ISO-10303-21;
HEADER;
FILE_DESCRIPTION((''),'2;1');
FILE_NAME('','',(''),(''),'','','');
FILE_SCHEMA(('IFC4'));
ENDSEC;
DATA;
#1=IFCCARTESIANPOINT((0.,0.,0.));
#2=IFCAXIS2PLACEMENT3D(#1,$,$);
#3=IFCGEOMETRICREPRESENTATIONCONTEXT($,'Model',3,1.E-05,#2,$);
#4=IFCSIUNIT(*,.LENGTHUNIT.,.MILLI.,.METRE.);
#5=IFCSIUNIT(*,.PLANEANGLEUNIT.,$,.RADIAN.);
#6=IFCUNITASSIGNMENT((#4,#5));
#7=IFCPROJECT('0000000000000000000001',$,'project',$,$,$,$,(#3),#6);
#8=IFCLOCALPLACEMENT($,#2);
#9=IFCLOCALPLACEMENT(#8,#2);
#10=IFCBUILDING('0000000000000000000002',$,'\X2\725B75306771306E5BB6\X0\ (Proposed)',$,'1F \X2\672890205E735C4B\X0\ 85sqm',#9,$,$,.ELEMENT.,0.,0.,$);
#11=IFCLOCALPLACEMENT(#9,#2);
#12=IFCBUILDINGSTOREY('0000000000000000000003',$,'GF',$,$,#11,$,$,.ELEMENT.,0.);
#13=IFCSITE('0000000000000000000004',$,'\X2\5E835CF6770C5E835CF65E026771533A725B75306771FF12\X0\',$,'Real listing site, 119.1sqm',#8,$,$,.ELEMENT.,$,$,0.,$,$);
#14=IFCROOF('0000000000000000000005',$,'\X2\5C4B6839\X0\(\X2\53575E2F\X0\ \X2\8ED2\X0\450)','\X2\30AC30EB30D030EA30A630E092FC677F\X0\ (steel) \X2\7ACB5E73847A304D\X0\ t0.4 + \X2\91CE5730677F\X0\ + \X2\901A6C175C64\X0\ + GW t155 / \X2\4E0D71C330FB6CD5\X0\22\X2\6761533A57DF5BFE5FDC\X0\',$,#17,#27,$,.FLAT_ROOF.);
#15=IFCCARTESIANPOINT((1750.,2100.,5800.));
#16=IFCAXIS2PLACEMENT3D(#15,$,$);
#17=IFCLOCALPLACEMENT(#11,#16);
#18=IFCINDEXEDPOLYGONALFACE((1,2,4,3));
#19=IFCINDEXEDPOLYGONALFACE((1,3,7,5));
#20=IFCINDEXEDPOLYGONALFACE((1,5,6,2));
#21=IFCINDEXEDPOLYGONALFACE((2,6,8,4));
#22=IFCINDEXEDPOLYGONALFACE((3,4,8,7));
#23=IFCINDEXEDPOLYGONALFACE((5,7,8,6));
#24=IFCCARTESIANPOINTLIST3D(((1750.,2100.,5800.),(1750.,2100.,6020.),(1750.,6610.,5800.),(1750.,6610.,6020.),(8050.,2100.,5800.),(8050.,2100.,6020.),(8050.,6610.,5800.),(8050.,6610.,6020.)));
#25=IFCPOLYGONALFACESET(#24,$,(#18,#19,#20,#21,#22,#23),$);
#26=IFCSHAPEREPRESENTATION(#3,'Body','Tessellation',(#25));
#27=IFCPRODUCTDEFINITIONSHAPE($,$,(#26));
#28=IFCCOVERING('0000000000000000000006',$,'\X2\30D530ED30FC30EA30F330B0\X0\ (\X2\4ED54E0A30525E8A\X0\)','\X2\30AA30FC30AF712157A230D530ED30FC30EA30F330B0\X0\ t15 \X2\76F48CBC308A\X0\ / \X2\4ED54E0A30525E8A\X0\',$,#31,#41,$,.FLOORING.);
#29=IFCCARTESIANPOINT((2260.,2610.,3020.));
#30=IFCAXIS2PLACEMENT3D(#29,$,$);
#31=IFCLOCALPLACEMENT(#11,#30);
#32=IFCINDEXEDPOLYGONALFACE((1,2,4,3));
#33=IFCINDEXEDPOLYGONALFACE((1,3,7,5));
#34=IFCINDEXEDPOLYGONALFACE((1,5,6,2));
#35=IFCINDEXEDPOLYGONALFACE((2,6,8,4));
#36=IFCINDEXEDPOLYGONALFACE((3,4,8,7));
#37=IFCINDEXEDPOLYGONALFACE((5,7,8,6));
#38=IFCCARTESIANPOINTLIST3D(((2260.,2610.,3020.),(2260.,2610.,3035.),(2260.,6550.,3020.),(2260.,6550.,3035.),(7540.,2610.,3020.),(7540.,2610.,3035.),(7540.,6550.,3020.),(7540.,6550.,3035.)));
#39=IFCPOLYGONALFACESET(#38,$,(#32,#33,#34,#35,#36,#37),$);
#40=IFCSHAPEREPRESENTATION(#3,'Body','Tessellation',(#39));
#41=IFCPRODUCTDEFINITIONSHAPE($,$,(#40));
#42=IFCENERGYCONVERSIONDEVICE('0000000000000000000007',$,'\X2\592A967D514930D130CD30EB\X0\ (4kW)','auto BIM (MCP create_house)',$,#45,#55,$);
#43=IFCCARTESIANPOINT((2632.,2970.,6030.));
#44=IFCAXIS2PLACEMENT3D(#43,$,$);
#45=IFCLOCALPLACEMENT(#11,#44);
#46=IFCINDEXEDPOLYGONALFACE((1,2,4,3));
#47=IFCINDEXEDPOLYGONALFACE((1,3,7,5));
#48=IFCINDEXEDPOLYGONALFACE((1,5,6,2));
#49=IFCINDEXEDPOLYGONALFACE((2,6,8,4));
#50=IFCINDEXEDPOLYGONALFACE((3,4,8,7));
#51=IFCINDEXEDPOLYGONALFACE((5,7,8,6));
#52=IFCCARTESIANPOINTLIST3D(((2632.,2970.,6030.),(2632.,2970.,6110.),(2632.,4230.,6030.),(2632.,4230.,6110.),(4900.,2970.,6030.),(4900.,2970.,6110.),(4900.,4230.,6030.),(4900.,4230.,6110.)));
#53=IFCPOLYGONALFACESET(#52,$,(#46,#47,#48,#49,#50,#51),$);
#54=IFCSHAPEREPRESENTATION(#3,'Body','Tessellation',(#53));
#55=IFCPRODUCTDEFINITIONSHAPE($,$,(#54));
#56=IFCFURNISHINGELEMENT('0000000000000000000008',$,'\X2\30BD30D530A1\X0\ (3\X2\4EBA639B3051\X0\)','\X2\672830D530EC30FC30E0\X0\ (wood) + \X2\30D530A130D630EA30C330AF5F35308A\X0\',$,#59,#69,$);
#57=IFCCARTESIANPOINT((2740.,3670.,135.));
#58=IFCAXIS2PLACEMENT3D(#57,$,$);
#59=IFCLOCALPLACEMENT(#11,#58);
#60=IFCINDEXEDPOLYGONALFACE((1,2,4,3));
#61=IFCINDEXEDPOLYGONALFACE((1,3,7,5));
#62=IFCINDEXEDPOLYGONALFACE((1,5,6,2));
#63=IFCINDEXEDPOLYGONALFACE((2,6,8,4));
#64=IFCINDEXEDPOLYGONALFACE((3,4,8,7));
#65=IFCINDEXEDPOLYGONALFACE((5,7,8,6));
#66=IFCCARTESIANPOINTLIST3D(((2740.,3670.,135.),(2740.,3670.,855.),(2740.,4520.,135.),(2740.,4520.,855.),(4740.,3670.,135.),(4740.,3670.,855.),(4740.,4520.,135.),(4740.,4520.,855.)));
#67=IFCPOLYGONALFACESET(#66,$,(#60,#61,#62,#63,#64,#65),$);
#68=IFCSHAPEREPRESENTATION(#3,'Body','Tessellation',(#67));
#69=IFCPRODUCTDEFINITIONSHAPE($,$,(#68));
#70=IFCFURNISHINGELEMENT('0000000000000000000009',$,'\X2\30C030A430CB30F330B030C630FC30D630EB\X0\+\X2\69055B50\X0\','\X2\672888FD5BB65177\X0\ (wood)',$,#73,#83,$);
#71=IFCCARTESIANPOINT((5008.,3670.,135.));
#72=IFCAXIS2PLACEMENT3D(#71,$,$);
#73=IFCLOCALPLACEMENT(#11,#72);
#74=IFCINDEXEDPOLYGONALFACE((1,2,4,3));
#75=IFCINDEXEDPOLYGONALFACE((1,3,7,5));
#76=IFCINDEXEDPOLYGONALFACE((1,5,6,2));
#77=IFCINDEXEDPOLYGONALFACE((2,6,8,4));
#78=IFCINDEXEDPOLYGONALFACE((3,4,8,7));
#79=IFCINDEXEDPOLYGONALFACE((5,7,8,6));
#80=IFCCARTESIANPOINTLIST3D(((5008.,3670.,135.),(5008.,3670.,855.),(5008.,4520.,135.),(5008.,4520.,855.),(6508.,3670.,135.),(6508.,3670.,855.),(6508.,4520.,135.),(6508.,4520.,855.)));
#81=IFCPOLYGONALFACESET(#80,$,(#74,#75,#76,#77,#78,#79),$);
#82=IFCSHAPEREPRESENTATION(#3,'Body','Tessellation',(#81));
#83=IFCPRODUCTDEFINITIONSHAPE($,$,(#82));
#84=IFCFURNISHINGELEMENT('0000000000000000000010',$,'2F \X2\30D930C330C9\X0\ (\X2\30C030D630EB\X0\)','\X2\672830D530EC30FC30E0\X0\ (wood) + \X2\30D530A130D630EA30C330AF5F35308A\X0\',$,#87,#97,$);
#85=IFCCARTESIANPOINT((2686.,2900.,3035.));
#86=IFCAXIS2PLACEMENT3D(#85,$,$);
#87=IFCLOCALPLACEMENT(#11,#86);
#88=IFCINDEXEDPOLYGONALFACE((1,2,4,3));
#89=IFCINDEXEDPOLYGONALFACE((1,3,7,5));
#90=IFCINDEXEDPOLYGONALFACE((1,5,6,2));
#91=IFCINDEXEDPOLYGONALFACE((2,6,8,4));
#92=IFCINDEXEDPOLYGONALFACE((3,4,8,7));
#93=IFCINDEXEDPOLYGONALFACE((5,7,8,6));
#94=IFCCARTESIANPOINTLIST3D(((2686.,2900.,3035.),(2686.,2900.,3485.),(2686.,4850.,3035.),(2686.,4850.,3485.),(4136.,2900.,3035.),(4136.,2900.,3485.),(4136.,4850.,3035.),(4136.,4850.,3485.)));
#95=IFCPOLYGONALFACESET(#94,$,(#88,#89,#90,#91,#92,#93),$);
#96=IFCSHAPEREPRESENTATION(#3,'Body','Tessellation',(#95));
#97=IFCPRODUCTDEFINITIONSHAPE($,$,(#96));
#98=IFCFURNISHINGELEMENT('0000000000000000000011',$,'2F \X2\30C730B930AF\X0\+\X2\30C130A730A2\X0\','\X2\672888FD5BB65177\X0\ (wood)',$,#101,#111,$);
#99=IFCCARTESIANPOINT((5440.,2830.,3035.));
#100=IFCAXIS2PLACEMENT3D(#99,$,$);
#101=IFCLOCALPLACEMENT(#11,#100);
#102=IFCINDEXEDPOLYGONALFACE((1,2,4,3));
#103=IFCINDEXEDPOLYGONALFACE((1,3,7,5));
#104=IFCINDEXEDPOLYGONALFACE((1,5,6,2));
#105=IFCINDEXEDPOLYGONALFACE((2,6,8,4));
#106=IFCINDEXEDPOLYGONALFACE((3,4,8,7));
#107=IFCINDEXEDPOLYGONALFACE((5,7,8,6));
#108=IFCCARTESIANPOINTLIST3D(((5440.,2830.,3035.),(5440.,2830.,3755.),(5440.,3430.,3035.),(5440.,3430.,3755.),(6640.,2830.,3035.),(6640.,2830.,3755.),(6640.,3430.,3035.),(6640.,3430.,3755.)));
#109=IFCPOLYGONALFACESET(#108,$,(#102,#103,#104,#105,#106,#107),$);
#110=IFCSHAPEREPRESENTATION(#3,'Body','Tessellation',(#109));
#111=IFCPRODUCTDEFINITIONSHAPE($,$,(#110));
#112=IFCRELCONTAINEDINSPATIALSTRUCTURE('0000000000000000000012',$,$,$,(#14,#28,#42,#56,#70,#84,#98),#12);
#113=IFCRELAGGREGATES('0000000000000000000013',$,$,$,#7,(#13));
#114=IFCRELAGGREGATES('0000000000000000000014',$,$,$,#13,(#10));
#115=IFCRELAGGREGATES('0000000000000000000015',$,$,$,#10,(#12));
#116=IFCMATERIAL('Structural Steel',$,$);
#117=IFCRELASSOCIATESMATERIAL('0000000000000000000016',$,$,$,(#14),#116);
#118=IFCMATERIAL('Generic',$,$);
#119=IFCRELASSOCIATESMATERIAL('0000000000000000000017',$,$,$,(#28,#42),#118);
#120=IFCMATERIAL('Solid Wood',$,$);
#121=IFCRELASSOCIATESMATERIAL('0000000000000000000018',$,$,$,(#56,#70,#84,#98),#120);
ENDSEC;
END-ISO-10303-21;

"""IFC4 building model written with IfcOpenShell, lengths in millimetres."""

from ifc_helpers import new_model, si_unit, frame, frame_2d, origin, place, context, project, spatial, rectangle, extrude, material, element, save


model = new_model("IFC4")

# Units and contexts
model_context = context("Model", 3, precision=1e-05, world=origin())
ifc_project = project(units=[si_unit("LENGTHUNIT", "METRE", prefix="MILLI"), si_unit("PLANEANGLEUNIT", "RADIAN")], contexts=[model_context])

# Site, building, storey
site_placement = place(None, origin())
site = spatial("IfcSite", under=ifc_project, at=site_placement, Name="広島県広島市東区牛田東２", ObjectType="Real listing site, 119.1sqm", CompositionType="ELEMENT", RefElevation=0.0)
building_placement = place(site_placement, origin())
building = spatial("IfcBuilding", under=site, at=building_placement, Name="牛田東の家 (Proposed)", ObjectType="1F 木造平屋 85sqm", CompositionType="ELEMENT", ElevationOfRefHeight=0.0, ElevationOfTerrain=0.0)
storey_placement = place(building_placement, origin())
storey = spatial("IfcBuildingStorey", under=building, at=storey_placement, Name="GF", CompositionType="ELEMENT", Elevation=0.0)

# Shared definitions
ifc_material_1 = material(Name="Solid Wood")

# Shared definitions
ifc_material_2 = material(Name="Generic")

# Roof
ifc_material_3 = material(Name="Structural Steel")
for number, where, name in (
    (1, (1750.0, 2100.0, 5800.0), "屋根(南帯 軒450)"),
):
    element("IfcRoof", number, at=place(storey_placement, frame(where)), inside=storey, material=ifc_material_3, Name=name, Description="ガルバリウム鋼板 (steel) 立平葺き t0.4 + 野地板 + 通気層 + GW t155 / 不燃・法22条区域対応", PredefinedType="FLAT_ROOF", context=model_context, shape_type="SweptSolid", body=[
        extrude(rectangle(XDim=6300.0, YDim=4510.0, at=frame_2d((3150.0, 2255.0))), frame((1750.0, 2100.0, 5800.0)), (0.0, 0.0, 1.0), 220.0),
    ])

# Covering
covering_placement = place(storey_placement, frame((2260.0, 2610.0, 3020.0)))
element("IfcCovering", 2, at=covering_placement, inside=storey, material=ifc_material_2, Name="フローリング (仕上げ床)", Description="オーク無垢フローリング t15 直貼り / 仕上げ床", PredefinedType="FLOORING", context=model_context, shape_type="SweptSolid", body=[
    extrude(rectangle(XDim=5280.0, YDim=3940.0, at=frame_2d((2640.0, 1970.0))), frame((2260.0, 2610.0, 3020.0)), (0.0, 0.0, 1.0), 15.0),
])

# Energy conversion device
energy_conversion_device_placement = place(storey_placement, frame((2632.0, 2970.0, 6030.0)))
element("IfcEnergyConversionDevice", 3, at=energy_conversion_device_placement, inside=storey, material=ifc_material_2, Name="太陽光パネル (4kW)", Description="auto BIM (MCP create_house)", context=model_context, shape_type="SweptSolid", body=[
    extrude(rectangle(XDim=2268.0, YDim=1260.0, at=frame_2d((1134.0, 630.0))), frame((2632.0, 2970.0, 6030.0)), (0.0, 0.0, 1.0), 80.0),
])

# Furnishing elements
furnishing_1_placement = place(storey_placement, frame((2740.0, 3670.0, 135.0)))
element("IfcFurnishingElement", 4, at=furnishing_1_placement, inside=storey, material=ifc_material_1, Name="ソファ (3人掛け)", Description="木フレーム (wood) + ファブリック張り", context=model_context, shape_type="SweptSolid", body=[
    extrude(rectangle(XDim=2000.0, YDim=850.0, at=frame_2d((1000.0, 425.0))), frame((2740.0, 3670.0, 135.0)), (0.0, 0.0, 1.0), 720.0),
])
furnishing_2_placement = place(storey_placement, frame((5008.0, 3670.0, 135.0)))
element("IfcFurnishingElement", 5, at=furnishing_2_placement, inside=storey, material=ifc_material_1, Name="ダイニングテーブル+椅子", Description="木製家具 (wood)", context=model_context, shape_type="SweptSolid", body=[
    extrude(rectangle(XDim=1500.0, YDim=850.0, at=frame_2d((750.0, 425.0))), frame((5008.0, 3670.0, 135.0)), (0.0, 0.0, 1.0), 720.0),
])
furnishing_3_placement = place(storey_placement, frame((2686.0, 2900.0, 3035.0)))
element("IfcFurnishingElement", 6, at=furnishing_3_placement, inside=storey, material=ifc_material_1, Name="2F ベッド (ダブル)", Description="木フレーム (wood) + ファブリック張り", context=model_context, shape_type="SweptSolid", body=[
    extrude(rectangle(XDim=1450.0, YDim=1950.0, at=frame_2d((725.0, 975.0))), frame((2686.0, 2900.0, 3035.0)), (0.0, 0.0, 1.0), 450.0),
])
furnishing_4_placement = place(storey_placement, frame((5440.0, 2830.0, 3035.0)))
element("IfcFurnishingElement", 7, at=furnishing_4_placement, inside=storey, material=ifc_material_1, Name="2F デスク+チェア", Description="木製家具 (wood)", context=model_context, shape_type="SweptSolid", body=[
    extrude(rectangle(XDim=1200.0, YDim=600.0, at=frame_2d((600.0, 300.0))), frame((5440.0, 2830.0, 3035.0)), (0.0, 0.0, 1.0), 720.0),
])

save(model, "model.ifc")
